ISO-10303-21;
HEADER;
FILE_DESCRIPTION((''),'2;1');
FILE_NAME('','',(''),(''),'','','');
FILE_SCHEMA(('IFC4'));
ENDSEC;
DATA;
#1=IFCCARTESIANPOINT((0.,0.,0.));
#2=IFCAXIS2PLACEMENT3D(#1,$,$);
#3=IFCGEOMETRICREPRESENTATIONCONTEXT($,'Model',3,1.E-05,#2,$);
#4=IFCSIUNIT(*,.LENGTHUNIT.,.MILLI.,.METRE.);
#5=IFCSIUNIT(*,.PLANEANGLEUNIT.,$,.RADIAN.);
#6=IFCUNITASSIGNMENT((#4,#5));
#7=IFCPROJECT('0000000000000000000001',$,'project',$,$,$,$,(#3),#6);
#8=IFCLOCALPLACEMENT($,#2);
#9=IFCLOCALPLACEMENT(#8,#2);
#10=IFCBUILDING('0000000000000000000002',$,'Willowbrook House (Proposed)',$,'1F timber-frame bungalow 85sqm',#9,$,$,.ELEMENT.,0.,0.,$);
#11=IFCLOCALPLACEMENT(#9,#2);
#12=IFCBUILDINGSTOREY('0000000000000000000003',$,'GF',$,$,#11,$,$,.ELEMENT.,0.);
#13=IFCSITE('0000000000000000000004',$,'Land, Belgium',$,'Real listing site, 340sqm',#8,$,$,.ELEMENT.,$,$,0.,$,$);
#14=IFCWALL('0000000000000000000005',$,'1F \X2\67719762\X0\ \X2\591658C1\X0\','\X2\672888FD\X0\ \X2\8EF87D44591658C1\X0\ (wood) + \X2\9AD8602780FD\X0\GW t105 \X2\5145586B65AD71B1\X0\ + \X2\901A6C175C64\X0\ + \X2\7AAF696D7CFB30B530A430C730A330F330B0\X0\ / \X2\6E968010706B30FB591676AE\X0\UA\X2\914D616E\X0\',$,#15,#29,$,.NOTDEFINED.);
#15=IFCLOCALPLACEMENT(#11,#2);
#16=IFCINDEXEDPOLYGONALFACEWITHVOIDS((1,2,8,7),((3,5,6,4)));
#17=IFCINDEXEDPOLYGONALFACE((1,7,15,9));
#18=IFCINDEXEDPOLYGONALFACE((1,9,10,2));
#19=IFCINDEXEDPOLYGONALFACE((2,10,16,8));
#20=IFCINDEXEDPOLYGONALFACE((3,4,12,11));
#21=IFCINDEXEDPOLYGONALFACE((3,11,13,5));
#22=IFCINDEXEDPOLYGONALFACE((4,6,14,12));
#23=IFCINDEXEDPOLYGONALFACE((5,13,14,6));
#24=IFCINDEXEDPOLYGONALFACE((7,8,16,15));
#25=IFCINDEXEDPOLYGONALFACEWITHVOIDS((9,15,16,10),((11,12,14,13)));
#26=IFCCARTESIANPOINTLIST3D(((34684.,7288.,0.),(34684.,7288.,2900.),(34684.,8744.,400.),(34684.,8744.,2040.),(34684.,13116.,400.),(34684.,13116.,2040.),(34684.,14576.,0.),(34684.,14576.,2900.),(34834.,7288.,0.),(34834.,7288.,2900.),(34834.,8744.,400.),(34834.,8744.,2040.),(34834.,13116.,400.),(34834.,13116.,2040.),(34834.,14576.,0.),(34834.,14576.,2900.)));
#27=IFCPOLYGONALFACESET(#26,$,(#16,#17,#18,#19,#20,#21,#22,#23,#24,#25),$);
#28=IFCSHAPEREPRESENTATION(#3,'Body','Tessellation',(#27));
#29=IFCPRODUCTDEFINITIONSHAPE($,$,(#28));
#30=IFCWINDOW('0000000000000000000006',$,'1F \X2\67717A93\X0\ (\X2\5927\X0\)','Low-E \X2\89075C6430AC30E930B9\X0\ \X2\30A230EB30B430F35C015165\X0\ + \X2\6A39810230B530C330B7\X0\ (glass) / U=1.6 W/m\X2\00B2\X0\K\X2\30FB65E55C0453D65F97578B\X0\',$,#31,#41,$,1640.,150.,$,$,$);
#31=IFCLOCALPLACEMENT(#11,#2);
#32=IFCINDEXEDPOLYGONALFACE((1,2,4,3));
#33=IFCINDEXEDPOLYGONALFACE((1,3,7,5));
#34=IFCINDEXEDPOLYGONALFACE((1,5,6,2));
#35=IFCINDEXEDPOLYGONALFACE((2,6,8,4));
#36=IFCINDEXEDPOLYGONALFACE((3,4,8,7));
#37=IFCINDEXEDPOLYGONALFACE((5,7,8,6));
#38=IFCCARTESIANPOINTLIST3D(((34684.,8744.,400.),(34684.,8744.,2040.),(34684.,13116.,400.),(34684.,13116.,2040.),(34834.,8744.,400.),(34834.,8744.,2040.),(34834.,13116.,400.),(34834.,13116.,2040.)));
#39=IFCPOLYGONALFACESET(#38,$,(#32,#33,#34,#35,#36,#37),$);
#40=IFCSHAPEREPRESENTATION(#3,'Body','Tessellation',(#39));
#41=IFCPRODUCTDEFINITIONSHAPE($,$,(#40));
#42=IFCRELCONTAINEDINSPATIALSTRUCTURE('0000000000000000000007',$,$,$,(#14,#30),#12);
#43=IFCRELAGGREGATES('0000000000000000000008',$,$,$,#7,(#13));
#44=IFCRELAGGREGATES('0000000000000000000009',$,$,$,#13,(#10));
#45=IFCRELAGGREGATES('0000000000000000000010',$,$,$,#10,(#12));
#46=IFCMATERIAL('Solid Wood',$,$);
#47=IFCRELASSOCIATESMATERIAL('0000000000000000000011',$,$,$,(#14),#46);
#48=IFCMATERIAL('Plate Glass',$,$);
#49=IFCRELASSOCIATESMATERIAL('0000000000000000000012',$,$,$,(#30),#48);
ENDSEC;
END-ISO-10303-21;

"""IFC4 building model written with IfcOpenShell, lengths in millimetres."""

from ifc_helpers import new_model, si_unit, frame, frame_2d, origin, place, context, project, spatial, rectangle, extrude, material, element, fill, save


model = new_model("IFC4")

# Units and contexts
model_context = context("Model", 3, precision=1e-05, world=origin())
ifc_project = project(units=[si_unit("LENGTHUNIT", "METRE", prefix="MILLI"), si_unit("PLANEANGLEUNIT", "RADIAN")], contexts=[model_context])

# Site, building, storey
site_placement = place(None, origin())
site = spatial("IfcSite", under=ifc_project, at=site_placement, Name="Land, Belgium", ObjectType="Real listing site, 340sqm", CompositionType="ELEMENT", RefElevation=0.0)
building_placement = place(site_placement, origin())
building = spatial("IfcBuilding", under=site, at=building_placement, Name="Willowbrook House (Proposed)", ObjectType="1F timber-frame bungalow 85sqm", CompositionType="ELEMENT", ElevationOfRefHeight=0.0, ElevationOfTerrain=0.0)
storey_placement = place(building_placement, origin())
storey = spatial("IfcBuildingStorey", under=building, at=storey_placement, Name="GF", CompositionType="ELEMENT", Elevation=0.0)

# Shared definitions
ifc_material_1 = material(Name="Solid Wood")

# Wall, opening, window
wall_1_placement = place(storey_placement, frame((17342.0, 3644.0, 0.0)))
wall_1 = element("IfcWall", 1, at=wall_1_placement, inside=storey, material=ifc_material_1, Name="1F 東面 外壁", Description="木製 軸組外壁 (wood) + 高性能GW t105 充填断熱 + 通気層 + 窯業系サイディング / 準耐火・外皮UA配慮", PredefinedType="NOTDEFINED", context=model_context, shape_type="SweptSolid", body=[
    extrude(rectangle(XDim=150.0, YDim=7288.0, at=frame_2d((75.0, 3644.0))), frame((17342.0, 3644.0, 0.0)), (0.0, 0.0, 1.0), 2900.0),
])
opening_placement = place(storey_placement, frame((17342.0, 4372.0, 200.0)))
opening = element("IfcOpeningElement", 2, at=opening_placement, cuts=wall_1, PredefinedType="NOTDEFINED", context=model_context, shape_type="SweptSolid", body=[
    extrude(rectangle(XDim=150.0, YDim=4372.0, at=frame_2d((75.0, 2186.0))), frame((17342.0, 4372.0, 200.0)), (0.0, 0.0, 1.0), 1640.0),
])
ifc_material_2 = material(Name="Plate Glass")
window_1_placement = place(storey_placement, frame((17342.0, 4372.0, 200.0)))
window_1 = element("IfcWindow", 3, at=window_1_placement, inside=storey, material=ifc_material_2, Name="1F 東窓 (大)", Description="Low-E 複層ガラス アルゴン封入 + 樹脂サッシ (glass) / U=1.6 W/m²K・日射取得型", OverallHeight=1640.0, OverallWidth=150.0, context=model_context, shape_type="SweptSolid", body=[
    extrude(rectangle(XDim=150.0, YDim=4372.0, at=frame_2d((75.0, 2186.0))), frame((17342.0, 4372.0, 200.0)), (0.0, 0.0, 1.0), 1640.0),
])
fill(opening, window_1)

save(model, "model.ifc")
